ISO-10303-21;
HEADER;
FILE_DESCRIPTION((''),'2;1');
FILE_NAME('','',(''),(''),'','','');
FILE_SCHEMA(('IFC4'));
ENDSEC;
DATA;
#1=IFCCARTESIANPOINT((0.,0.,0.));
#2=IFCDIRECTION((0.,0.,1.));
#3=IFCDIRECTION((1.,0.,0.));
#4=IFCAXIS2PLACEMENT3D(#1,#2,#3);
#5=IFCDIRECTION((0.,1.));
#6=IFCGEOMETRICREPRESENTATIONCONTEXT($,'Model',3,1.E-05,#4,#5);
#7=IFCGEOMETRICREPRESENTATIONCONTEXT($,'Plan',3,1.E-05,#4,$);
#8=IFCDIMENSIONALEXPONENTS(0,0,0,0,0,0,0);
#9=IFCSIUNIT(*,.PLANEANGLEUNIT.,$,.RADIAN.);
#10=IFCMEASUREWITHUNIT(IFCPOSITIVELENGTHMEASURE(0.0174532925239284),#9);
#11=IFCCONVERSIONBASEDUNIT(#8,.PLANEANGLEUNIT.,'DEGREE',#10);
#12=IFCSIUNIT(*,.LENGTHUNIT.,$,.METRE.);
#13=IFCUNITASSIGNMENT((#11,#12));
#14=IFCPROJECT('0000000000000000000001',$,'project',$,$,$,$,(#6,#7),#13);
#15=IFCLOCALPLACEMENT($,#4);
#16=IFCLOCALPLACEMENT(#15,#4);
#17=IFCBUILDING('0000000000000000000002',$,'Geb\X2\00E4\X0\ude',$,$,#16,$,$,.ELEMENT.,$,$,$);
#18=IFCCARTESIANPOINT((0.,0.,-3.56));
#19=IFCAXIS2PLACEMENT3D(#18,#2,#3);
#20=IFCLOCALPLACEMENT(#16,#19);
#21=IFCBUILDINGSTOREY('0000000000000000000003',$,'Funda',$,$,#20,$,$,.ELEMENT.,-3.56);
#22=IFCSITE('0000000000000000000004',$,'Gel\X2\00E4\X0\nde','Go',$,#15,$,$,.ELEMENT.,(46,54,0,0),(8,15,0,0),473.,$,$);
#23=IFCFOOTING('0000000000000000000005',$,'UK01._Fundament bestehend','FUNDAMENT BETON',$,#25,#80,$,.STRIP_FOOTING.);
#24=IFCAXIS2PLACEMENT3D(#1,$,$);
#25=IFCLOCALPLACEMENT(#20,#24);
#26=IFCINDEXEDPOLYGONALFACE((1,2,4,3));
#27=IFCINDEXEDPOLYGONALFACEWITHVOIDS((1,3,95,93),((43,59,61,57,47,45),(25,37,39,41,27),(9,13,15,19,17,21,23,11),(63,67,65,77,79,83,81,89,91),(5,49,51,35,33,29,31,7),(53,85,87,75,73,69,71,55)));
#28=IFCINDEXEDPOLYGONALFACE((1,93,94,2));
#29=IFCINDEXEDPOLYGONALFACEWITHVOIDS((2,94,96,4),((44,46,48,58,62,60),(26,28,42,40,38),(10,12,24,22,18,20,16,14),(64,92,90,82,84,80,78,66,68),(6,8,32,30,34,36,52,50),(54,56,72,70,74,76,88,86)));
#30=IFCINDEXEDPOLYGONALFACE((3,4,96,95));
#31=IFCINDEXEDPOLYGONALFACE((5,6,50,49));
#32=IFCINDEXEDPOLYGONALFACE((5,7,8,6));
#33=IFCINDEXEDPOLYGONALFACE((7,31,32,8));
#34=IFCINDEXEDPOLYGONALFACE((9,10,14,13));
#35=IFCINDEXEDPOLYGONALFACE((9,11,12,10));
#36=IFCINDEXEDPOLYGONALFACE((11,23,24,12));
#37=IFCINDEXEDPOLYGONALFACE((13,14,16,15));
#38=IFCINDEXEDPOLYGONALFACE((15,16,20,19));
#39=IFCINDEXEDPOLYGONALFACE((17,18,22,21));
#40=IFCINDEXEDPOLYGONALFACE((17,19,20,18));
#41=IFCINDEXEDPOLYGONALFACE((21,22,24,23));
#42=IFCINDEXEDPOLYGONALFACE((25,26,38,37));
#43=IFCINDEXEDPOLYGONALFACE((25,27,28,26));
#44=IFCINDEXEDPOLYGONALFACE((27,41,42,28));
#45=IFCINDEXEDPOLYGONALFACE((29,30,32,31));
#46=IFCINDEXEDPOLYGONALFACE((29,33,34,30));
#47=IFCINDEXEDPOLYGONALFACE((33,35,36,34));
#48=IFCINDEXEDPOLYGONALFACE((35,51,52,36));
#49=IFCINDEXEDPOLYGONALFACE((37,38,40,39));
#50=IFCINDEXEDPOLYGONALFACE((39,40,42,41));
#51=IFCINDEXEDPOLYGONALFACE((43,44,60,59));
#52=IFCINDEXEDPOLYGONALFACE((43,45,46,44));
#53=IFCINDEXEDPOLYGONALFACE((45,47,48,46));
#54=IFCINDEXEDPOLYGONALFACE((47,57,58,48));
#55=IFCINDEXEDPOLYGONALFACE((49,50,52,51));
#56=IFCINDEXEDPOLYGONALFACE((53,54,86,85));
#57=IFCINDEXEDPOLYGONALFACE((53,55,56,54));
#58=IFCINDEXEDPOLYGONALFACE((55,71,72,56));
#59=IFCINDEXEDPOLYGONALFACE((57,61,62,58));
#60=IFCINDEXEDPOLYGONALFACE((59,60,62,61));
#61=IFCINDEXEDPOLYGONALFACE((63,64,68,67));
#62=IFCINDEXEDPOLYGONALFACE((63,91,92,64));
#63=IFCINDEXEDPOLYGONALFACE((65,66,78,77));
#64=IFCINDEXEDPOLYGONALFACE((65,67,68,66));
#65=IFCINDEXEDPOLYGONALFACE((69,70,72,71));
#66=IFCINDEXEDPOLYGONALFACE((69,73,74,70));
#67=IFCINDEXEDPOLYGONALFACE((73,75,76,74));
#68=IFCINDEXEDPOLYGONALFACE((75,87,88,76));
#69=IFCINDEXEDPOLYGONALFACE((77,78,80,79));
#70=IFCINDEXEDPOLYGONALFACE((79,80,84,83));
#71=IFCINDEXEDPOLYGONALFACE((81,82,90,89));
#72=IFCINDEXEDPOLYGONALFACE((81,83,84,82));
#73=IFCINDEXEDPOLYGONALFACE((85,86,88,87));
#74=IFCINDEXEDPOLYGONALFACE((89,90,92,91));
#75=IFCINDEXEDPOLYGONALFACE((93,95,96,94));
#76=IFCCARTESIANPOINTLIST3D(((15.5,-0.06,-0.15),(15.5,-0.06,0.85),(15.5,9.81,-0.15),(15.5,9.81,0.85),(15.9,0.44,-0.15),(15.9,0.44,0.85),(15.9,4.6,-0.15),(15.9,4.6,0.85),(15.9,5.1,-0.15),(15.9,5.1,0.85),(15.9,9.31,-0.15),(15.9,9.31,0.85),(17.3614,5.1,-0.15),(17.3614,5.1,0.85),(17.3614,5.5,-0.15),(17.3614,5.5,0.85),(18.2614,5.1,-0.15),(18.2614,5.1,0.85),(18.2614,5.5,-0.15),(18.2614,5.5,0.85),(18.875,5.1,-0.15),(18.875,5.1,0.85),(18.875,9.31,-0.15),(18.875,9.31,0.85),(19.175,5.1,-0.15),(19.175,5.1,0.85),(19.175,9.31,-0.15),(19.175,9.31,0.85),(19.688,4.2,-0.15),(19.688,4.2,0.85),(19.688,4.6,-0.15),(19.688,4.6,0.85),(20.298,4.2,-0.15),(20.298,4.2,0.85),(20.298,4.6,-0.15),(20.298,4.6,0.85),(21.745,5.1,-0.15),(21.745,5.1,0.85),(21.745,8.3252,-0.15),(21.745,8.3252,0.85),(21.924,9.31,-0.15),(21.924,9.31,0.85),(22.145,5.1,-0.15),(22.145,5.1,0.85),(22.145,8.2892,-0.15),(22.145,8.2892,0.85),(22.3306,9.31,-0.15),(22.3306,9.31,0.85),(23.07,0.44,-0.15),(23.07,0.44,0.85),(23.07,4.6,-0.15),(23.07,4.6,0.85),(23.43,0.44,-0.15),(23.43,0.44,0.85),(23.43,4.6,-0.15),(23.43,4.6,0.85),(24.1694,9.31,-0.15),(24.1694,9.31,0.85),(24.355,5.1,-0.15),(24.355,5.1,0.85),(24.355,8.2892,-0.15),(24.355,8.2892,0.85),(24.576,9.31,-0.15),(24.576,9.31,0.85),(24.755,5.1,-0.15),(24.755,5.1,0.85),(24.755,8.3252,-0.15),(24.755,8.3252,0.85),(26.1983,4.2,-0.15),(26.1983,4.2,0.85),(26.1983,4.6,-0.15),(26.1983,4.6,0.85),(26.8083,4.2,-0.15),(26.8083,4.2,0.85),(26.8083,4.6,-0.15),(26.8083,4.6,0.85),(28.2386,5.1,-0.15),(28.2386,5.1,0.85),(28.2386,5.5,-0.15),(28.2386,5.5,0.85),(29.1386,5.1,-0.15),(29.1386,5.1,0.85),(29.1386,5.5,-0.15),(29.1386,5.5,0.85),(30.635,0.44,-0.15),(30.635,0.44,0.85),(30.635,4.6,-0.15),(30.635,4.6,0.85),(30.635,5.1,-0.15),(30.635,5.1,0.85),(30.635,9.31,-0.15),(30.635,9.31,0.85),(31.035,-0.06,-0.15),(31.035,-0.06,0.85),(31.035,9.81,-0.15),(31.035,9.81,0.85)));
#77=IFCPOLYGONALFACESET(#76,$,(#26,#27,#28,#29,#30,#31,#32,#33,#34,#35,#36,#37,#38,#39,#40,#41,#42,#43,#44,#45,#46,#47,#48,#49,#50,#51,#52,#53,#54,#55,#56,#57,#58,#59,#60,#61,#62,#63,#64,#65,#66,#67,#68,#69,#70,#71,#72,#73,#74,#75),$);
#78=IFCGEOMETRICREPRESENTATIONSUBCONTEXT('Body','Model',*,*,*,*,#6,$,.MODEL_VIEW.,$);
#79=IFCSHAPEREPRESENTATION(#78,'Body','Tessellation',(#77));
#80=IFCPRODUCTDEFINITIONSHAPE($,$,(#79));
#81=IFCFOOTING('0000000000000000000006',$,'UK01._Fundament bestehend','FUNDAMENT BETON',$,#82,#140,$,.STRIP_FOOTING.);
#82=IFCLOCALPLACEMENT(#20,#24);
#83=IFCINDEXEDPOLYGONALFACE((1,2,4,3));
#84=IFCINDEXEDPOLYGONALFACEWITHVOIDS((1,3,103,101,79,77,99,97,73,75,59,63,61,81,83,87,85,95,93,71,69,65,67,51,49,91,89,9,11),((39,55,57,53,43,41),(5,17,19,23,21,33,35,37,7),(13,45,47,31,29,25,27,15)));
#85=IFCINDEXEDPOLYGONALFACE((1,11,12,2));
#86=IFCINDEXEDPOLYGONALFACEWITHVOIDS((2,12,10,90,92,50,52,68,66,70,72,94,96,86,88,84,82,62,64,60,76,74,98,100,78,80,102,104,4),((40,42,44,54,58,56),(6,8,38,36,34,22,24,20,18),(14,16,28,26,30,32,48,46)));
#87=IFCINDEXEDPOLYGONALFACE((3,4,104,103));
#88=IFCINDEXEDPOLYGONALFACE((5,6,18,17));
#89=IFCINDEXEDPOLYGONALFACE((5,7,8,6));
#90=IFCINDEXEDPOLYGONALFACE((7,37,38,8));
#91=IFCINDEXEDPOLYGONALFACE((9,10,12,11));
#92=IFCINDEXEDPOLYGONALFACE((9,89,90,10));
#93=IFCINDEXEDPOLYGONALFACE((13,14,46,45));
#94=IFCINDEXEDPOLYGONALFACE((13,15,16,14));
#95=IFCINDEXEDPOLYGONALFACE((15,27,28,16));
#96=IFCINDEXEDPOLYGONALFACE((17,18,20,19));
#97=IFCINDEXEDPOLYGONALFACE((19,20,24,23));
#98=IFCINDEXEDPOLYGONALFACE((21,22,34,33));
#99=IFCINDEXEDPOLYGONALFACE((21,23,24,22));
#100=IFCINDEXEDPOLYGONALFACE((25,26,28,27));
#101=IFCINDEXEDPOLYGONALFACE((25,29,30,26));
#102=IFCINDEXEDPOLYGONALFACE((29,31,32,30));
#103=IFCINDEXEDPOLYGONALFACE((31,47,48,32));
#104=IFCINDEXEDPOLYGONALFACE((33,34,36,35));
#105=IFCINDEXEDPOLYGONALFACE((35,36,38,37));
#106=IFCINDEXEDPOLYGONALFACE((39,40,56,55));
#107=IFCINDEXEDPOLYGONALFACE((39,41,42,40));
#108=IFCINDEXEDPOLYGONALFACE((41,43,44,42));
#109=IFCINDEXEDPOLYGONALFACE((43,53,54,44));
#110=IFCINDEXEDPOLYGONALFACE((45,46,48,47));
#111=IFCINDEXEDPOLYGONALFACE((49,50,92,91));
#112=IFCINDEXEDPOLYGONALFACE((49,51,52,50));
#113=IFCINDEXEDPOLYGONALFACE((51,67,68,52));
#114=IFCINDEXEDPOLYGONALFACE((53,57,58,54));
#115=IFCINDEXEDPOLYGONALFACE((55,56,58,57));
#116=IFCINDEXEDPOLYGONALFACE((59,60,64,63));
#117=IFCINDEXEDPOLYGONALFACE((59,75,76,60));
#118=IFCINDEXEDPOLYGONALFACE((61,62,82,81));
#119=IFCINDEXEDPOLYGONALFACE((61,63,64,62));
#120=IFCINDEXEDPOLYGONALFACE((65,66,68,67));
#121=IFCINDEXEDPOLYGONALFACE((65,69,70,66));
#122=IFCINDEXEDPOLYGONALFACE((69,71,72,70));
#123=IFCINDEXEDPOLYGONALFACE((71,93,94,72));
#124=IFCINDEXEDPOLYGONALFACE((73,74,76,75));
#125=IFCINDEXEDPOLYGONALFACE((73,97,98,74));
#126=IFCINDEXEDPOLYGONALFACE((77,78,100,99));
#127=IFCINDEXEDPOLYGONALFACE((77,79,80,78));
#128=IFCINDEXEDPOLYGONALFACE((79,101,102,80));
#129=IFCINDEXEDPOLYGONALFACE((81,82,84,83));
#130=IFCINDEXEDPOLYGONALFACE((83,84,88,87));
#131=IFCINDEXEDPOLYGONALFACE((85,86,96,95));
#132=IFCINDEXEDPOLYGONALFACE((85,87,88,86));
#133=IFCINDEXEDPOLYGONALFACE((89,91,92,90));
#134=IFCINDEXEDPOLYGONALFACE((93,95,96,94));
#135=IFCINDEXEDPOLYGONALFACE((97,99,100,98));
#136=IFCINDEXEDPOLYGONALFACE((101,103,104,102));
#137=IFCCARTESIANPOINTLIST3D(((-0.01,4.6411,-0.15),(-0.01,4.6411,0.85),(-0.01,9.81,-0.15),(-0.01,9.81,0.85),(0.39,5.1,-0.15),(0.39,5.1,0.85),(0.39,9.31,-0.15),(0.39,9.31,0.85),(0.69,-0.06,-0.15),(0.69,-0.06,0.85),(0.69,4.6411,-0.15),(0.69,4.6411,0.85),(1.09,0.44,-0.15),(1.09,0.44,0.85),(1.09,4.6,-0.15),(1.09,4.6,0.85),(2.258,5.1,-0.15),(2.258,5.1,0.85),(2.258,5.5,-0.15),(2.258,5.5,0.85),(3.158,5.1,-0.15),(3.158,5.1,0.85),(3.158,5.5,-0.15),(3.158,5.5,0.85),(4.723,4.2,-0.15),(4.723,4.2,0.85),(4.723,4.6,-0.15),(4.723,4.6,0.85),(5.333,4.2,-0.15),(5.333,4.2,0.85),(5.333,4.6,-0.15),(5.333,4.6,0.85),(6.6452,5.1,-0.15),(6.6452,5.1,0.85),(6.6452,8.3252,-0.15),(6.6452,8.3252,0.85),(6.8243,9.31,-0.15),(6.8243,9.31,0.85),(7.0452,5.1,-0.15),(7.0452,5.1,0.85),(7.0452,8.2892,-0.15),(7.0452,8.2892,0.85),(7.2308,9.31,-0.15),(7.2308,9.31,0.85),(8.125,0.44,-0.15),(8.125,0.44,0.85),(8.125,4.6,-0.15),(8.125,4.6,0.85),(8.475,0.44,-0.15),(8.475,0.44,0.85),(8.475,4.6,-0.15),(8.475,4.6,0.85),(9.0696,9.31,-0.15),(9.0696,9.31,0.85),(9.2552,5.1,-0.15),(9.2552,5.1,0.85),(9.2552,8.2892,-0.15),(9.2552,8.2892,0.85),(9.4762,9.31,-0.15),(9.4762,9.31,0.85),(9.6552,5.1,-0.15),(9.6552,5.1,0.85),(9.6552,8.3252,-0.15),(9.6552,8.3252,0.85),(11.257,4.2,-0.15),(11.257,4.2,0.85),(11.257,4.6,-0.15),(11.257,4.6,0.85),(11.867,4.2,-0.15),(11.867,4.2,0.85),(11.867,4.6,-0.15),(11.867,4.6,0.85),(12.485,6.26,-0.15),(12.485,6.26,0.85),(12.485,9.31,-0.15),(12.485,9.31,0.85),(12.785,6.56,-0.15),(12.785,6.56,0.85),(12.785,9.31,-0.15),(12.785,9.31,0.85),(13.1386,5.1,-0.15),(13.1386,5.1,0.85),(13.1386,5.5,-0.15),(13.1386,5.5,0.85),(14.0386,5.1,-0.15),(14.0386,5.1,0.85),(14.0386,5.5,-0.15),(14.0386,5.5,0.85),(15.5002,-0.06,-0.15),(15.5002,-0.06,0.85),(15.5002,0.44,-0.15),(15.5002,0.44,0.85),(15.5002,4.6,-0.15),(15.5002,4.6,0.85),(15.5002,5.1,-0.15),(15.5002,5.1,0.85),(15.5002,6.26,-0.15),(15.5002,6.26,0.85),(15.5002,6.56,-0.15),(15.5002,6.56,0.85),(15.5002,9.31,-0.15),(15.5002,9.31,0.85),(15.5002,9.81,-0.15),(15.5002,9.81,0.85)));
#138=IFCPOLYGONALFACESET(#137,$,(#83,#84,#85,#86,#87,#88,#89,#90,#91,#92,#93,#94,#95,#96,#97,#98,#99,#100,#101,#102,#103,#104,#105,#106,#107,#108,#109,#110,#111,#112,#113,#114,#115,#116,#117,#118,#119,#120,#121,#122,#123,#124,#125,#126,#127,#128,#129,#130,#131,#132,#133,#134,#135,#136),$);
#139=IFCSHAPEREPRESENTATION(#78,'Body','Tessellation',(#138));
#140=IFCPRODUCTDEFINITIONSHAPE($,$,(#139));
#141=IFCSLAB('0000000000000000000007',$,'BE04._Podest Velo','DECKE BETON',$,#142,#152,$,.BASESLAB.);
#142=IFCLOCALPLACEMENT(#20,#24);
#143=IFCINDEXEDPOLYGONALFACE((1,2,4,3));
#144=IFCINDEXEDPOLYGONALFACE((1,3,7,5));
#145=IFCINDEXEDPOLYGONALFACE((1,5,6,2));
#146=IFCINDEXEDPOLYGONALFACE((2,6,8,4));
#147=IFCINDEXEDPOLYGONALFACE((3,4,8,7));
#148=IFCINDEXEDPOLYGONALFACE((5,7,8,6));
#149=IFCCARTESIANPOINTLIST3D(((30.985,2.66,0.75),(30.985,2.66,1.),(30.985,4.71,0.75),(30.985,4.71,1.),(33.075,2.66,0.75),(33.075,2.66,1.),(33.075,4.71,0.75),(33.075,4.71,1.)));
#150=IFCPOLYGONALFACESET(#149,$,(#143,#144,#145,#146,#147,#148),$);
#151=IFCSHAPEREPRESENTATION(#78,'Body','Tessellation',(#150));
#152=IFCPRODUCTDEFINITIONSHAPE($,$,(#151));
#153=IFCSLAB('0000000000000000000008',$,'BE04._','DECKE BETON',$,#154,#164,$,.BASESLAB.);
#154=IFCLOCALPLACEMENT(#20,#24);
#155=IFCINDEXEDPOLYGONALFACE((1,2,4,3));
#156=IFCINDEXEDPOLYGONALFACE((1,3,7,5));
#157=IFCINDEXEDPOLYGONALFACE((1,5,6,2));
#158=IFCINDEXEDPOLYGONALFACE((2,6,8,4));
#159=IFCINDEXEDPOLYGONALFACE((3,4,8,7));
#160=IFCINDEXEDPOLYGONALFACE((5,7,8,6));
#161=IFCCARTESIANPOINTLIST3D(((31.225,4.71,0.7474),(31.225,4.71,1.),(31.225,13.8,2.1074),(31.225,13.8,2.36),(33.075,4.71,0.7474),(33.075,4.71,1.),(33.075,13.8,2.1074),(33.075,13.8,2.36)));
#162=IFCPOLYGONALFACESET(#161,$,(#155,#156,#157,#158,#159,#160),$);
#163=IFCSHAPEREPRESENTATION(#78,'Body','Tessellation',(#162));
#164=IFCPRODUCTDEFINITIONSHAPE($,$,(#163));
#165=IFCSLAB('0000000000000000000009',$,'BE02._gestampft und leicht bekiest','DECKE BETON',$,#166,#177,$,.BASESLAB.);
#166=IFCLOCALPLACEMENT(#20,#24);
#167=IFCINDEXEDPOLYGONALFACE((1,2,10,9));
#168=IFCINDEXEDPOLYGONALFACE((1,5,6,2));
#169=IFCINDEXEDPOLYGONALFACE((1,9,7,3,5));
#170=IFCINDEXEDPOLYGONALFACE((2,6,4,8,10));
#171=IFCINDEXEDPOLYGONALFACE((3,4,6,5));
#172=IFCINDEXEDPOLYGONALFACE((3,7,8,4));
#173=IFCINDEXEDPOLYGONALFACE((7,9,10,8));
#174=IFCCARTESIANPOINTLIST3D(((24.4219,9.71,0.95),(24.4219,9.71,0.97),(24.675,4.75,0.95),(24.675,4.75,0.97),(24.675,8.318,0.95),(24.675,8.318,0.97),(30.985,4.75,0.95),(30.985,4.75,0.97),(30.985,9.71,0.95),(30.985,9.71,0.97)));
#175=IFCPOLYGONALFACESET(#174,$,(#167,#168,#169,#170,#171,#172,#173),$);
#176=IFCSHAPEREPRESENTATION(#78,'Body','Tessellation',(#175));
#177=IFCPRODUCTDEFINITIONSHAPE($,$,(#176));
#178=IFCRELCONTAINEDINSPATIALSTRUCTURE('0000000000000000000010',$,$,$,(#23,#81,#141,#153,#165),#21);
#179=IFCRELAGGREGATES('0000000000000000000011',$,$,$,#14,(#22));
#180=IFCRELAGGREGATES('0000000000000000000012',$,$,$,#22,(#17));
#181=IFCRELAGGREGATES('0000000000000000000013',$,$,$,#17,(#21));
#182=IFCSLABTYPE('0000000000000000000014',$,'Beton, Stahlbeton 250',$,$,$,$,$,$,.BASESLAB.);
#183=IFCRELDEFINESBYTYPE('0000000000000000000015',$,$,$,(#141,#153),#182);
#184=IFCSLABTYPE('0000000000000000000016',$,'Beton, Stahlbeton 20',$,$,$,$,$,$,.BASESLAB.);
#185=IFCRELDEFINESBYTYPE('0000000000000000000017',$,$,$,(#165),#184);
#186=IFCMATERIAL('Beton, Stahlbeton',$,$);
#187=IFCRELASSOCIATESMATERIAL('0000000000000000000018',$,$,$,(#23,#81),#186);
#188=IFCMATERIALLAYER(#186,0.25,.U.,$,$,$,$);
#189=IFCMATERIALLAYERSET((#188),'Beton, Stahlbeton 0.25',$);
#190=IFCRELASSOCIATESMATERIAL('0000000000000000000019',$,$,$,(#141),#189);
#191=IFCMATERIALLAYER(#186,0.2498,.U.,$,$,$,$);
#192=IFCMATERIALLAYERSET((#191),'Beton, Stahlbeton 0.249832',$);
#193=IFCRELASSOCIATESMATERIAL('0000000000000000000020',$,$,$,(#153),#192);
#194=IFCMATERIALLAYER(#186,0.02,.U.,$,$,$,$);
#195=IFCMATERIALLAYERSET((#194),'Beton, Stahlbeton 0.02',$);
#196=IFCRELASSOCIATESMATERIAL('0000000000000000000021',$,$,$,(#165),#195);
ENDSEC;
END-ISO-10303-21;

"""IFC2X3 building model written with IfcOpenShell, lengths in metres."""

from ifc_helpers import new_model, entity, si_unit, converted_unit, direction, frame, origin_with_axes, place, context, subcontext, project, spatial, polyline, outline, extrude, material, layer, layer_set, layer_usage, type_object, element, save


model = new_model("IFC2X3")

# Units and contexts
model_context = context("Model", 3, precision=1e-05, world=origin_with_axes(), true_north=direction((0.0, 1.0)))
plan_context = context("Plan", 3, precision=1e-05, world=origin_with_axes())
body_context = subcontext(model_context, "Body", "Model", "MODEL_VIEW")
ifc_project = project(units=[converted_unit("PLANEANGLEUNIT", "DEGREE", entity("IfcPositiveLengthMeasure", 0.0174532925239284), si_unit("PLANEANGLEUNIT", "RADIAN"), dimensions=[0, 0, 0, 0, 0, 0, 0]), si_unit("LENGTHUNIT", "METRE")], contexts=[model_context, plan_context])

# Site, building, storey
site_placement = place(None, origin_with_axes())
site = spatial("IfcSite", under=ifc_project, at=site_placement, Name="Gelände", Description="Go", CompositionType="ELEMENT", RefLatitude=(46, 54, 0, 0), RefLongitude=(8, 15, 0, 0), RefElevation=473.0)
building_placement = place(site_placement, origin_with_axes())
building = spatial("IfcBuilding", under=site, at=building_placement, Name="Gebäude", CompositionType="ELEMENT")
storey_placement = place(building_placement, frame((0.0, 0.0, -3.56), z_axis=(0.0, 0.0, 1.0), x_axis=(1.0, 0.0, 0.0)))
storey = spatial("IfcBuildingStorey", under=building, at=storey_placement, Name="Funda", CompositionType="ELEMENT", Elevation=-3.56)

# Footings
ifc_material = material(Name="Beton, Stahlbeton")
footing_1_placement = place(storey_placement, frame((15.5, -0.06, 0.85), z_axis=(0.0, 0.0, 1.0), x_axis=(1.0, 0.0, 0.0)))
element("IfcFooting", 1, at=footing_1_placement, inside=storey, material=ifc_material, Name="UK01._Fundament bestehend", Description="FUNDAMENT BETON", PredefinedType="STRIP_FOOTING", context=body_context, shape_type="SweptSolid", body=[
    extrude(outline(polyline([(0.0, 0.0), (15.535, 0.0), (15.535, 9.87), (0.0, 9.87), (0.0, 0.0)]), holes=[polyline([(0.4, 0.5), (0.4, 4.66), (4.188, 4.66), (4.188, 4.26), (4.798, 4.26), (4.798, 4.66), (7.57, 4.66), (7.57, 0.5), (0.4, 0.5)]), polyline([(0.4, 9.37), (3.375, 9.37), (3.375, 5.16), (2.7614, 5.16), (2.7614, 5.56), (1.8614, 5.56), (1.8614, 5.16), (0.4, 5.16), (0.4, 9.37)]), polyline([(3.675, 5.16), (3.675, 9.37), (6.424, 9.37), (6.245, 8.3852), (6.245, 5.16), (3.675, 5.16)]), polyline([(6.645, 8.3492), (6.8306, 9.37), (8.6694, 9.37), (8.855, 8.3492), (8.855, 5.16), (6.645, 5.16), (6.645, 8.3492)]), polyline([(7.93, 4.66), (10.6983, 4.66), (10.6983, 4.26), (11.3083, 4.26), (11.3083, 4.66), (15.135, 4.66), (15.135, 0.5), (7.93, 0.5), (7.93, 4.66)]), polyline([(9.076, 9.37), (15.135, 9.37), (15.135, 5.16), (13.6386, 5.16), (13.6386, 5.56), (12.7386, 5.56), (12.7386, 5.16), (9.255, 5.16), (9.255, 8.3852), (9.076, 9.37)])]), frame((0.0, 0.0, -1.0), z_axis=(0.0, 0.0, 1.0), x_axis=(1.0, 0.0, 0.0)), (0.0, 0.0, 1.0), 1.0),
])
footing_2_placement = place(storey_placement, frame((-0.01, 9.81, 0.85), z_axis=(0.0, 0.0, 1.0), x_axis=(1.0, 0.0, 0.0)))
element("IfcFooting", 2, at=footing_2_placement, inside=storey, material=ifc_material, Name="UK01._Fundament bestehend", Description="FUNDAMENT BETON", PredefinedType="STRIP_FOOTING", context=body_context, shape_type="SweptSolid", body=[
    extrude(outline(polyline([(0.0, 0.0), (0.0, -5.1689), (0.7, -5.1689), (0.7, -9.87), (15.5102, -9.87), (15.5102, -9.37), (8.485, -9.37), (8.485, -5.21), (11.267, -5.21), (11.267, -5.61), (11.877, -5.61), (11.877, -5.21), (15.5102, -5.21), (15.5102, -4.71), (14.0486, -4.71), (14.0486, -4.31), (13.1486, -4.31), (13.1486, -4.71), (9.6652, -4.71), (9.6652, -1.4848), (9.4862, -0.5), (12.495, -0.5), (12.495, -3.55), (15.5102, -3.55), (15.5102, -3.25), (12.795, -3.25), (12.795, -0.5), (15.5102, -0.5), (15.5102, 0.0), (0.0, 0.0)]), holes=[polyline([(0.4, -4.71), (0.4, -0.5), (6.8343, -0.5), (6.6552, -1.4848), (6.6552, -4.71), (3.168, -4.71), (3.168, -4.31), (2.268, -4.31), (2.268, -4.71), (0.4, -4.71)]), polyline([(8.135, -9.37), (1.1, -9.37), (1.1, -5.21), (4.733, -5.21), (4.733, -5.61), (5.343, -5.61), (5.343, -5.21), (8.135, -5.21), (8.135, -9.37)]), polyline([(7.0552, -4.71), (7.0552, -1.5208), (7.2408, -0.5), (9.0796, -0.5), (9.2652, -1.5208), (9.2652, -4.71), (7.0552, -4.71)])]), frame((0.0, 0.0, -1.0), z_axis=(0.0, 0.0, 1.0), x_axis=(1.0, 0.0, 0.0)), (0.0, 0.0, 1.0), 1.0),
])

# Slabs
ifc_layer_1 = layer(ifc_material, 0.25, ventilated="UNKNOWN")
ifc_layer_set_1 = layer_set([ifc_layer_1], Name="Beton, Stahlbeton 0.25")
ifc_layer_usage_1 = layer_usage(ifc_layer_set_1, "AXIS3", "NEGATIVE", 0.25)
slab_type_1 = type_object("IfcSlabType", Name="Beton, Stahlbeton 250", PredefinedType="BASESLAB")
slab_1_placement = place(storey_placement, frame((30.985, 2.66, 1.0), z_axis=(0.0, 0.0, 1.0), x_axis=(1.0, 0.0, 0.0)))
element("IfcSlab", 3, at=slab_1_placement, inside=storey, type_object=slab_type_1, material=ifc_layer_usage_1, Name="BE04._Podest Velo", Description="DECKE BETON", PredefinedType="BASESLAB", context=body_context, shape_type="SweptSolid", body=[
    extrude(outline(polyline([(0.0, 0.0), (2.09, 0.0), (2.09, 2.05), (0.0, 2.05), (0.0, 0.0)])), frame((0.0, 0.0, -0.25), z_axis=(0.0, 0.0, 1.0), x_axis=(1.0, 0.0, 0.0)), (0.0, 0.0, 1.0), 0.25),
])
ifc_layer_2 = layer(ifc_material, 0.2498, ventilated="UNKNOWN")
ifc_layer_set_2 = layer_set([ifc_layer_2], Name="Beton, Stahlbeton 0.249832")
ifc_layer_usage_2 = layer_usage(ifc_layer_set_2, "AXIS3", "NEGATIVE", 0.2498)
slab_2_placement = place(storey_placement, frame((31.225, 4.71, 0.7474), z_axis=(0.0, 0.0, 1.0), x_axis=(1.0, 0.0, 0.0)))
element("IfcSlab", 4, at=slab_2_placement, inside=storey, type_object=slab_type_1, material=ifc_layer_usage_2, Name="BE04._", Description="DECKE BETON", PredefinedType="BASESLAB", context=body_context, shape_type="SweptSolid", body=[
    extrude(outline(polyline([(0.0, 0.0), (1.85, 0.0), (1.85, 9.1912), (0.0, 9.1912), (0.0, 0.0)])), frame((0.0, 0.0, 0.0), z_axis=(0.0, -0.147968, 0.988992), x_axis=(1.0, 0.0, 0.0)), (0.0, 0.147968, 0.988992), 0.2526),
])
ifc_layer_3 = layer(ifc_material, 0.02, ventilated="UNKNOWN")
ifc_layer_set_3 = layer_set([ifc_layer_3], Name="Beton, Stahlbeton 0.02")
ifc_layer_usage_3 = layer_usage(ifc_layer_set_3, "AXIS3", "NEGATIVE", 0.02)
slab_type_2 = type_object("IfcSlabType", Name="Beton, Stahlbeton 20", PredefinedType="BASESLAB")
slab_3_placement = place(storey_placement, frame((24.4219, 9.71, 0.97), z_axis=(0.0, 0.0, 1.0), x_axis=(1.0, 0.0, 0.0)))
element("IfcSlab", 5, at=slab_3_placement, inside=storey, type_object=slab_type_2, material=ifc_layer_usage_3, Name="BE02._gestampft und leicht bekiest", Description="DECKE BETON", PredefinedType="BASESLAB", context=body_context, shape_type="SweptSolid", body=[
    extrude(outline(polyline([(0.0, 0.0), (0.2531, -1.392), (0.2531, -4.96), (6.5631, -4.96), (6.5631, 0.0), (0.0, 0.0)])), frame((0.0, 0.0, -0.02), z_axis=(0.0, 0.0, 1.0), x_axis=(1.0, 0.0, 0.0)), (0.0, 0.0, 1.0), 0.02),
])

save(model, "model.ifc")
